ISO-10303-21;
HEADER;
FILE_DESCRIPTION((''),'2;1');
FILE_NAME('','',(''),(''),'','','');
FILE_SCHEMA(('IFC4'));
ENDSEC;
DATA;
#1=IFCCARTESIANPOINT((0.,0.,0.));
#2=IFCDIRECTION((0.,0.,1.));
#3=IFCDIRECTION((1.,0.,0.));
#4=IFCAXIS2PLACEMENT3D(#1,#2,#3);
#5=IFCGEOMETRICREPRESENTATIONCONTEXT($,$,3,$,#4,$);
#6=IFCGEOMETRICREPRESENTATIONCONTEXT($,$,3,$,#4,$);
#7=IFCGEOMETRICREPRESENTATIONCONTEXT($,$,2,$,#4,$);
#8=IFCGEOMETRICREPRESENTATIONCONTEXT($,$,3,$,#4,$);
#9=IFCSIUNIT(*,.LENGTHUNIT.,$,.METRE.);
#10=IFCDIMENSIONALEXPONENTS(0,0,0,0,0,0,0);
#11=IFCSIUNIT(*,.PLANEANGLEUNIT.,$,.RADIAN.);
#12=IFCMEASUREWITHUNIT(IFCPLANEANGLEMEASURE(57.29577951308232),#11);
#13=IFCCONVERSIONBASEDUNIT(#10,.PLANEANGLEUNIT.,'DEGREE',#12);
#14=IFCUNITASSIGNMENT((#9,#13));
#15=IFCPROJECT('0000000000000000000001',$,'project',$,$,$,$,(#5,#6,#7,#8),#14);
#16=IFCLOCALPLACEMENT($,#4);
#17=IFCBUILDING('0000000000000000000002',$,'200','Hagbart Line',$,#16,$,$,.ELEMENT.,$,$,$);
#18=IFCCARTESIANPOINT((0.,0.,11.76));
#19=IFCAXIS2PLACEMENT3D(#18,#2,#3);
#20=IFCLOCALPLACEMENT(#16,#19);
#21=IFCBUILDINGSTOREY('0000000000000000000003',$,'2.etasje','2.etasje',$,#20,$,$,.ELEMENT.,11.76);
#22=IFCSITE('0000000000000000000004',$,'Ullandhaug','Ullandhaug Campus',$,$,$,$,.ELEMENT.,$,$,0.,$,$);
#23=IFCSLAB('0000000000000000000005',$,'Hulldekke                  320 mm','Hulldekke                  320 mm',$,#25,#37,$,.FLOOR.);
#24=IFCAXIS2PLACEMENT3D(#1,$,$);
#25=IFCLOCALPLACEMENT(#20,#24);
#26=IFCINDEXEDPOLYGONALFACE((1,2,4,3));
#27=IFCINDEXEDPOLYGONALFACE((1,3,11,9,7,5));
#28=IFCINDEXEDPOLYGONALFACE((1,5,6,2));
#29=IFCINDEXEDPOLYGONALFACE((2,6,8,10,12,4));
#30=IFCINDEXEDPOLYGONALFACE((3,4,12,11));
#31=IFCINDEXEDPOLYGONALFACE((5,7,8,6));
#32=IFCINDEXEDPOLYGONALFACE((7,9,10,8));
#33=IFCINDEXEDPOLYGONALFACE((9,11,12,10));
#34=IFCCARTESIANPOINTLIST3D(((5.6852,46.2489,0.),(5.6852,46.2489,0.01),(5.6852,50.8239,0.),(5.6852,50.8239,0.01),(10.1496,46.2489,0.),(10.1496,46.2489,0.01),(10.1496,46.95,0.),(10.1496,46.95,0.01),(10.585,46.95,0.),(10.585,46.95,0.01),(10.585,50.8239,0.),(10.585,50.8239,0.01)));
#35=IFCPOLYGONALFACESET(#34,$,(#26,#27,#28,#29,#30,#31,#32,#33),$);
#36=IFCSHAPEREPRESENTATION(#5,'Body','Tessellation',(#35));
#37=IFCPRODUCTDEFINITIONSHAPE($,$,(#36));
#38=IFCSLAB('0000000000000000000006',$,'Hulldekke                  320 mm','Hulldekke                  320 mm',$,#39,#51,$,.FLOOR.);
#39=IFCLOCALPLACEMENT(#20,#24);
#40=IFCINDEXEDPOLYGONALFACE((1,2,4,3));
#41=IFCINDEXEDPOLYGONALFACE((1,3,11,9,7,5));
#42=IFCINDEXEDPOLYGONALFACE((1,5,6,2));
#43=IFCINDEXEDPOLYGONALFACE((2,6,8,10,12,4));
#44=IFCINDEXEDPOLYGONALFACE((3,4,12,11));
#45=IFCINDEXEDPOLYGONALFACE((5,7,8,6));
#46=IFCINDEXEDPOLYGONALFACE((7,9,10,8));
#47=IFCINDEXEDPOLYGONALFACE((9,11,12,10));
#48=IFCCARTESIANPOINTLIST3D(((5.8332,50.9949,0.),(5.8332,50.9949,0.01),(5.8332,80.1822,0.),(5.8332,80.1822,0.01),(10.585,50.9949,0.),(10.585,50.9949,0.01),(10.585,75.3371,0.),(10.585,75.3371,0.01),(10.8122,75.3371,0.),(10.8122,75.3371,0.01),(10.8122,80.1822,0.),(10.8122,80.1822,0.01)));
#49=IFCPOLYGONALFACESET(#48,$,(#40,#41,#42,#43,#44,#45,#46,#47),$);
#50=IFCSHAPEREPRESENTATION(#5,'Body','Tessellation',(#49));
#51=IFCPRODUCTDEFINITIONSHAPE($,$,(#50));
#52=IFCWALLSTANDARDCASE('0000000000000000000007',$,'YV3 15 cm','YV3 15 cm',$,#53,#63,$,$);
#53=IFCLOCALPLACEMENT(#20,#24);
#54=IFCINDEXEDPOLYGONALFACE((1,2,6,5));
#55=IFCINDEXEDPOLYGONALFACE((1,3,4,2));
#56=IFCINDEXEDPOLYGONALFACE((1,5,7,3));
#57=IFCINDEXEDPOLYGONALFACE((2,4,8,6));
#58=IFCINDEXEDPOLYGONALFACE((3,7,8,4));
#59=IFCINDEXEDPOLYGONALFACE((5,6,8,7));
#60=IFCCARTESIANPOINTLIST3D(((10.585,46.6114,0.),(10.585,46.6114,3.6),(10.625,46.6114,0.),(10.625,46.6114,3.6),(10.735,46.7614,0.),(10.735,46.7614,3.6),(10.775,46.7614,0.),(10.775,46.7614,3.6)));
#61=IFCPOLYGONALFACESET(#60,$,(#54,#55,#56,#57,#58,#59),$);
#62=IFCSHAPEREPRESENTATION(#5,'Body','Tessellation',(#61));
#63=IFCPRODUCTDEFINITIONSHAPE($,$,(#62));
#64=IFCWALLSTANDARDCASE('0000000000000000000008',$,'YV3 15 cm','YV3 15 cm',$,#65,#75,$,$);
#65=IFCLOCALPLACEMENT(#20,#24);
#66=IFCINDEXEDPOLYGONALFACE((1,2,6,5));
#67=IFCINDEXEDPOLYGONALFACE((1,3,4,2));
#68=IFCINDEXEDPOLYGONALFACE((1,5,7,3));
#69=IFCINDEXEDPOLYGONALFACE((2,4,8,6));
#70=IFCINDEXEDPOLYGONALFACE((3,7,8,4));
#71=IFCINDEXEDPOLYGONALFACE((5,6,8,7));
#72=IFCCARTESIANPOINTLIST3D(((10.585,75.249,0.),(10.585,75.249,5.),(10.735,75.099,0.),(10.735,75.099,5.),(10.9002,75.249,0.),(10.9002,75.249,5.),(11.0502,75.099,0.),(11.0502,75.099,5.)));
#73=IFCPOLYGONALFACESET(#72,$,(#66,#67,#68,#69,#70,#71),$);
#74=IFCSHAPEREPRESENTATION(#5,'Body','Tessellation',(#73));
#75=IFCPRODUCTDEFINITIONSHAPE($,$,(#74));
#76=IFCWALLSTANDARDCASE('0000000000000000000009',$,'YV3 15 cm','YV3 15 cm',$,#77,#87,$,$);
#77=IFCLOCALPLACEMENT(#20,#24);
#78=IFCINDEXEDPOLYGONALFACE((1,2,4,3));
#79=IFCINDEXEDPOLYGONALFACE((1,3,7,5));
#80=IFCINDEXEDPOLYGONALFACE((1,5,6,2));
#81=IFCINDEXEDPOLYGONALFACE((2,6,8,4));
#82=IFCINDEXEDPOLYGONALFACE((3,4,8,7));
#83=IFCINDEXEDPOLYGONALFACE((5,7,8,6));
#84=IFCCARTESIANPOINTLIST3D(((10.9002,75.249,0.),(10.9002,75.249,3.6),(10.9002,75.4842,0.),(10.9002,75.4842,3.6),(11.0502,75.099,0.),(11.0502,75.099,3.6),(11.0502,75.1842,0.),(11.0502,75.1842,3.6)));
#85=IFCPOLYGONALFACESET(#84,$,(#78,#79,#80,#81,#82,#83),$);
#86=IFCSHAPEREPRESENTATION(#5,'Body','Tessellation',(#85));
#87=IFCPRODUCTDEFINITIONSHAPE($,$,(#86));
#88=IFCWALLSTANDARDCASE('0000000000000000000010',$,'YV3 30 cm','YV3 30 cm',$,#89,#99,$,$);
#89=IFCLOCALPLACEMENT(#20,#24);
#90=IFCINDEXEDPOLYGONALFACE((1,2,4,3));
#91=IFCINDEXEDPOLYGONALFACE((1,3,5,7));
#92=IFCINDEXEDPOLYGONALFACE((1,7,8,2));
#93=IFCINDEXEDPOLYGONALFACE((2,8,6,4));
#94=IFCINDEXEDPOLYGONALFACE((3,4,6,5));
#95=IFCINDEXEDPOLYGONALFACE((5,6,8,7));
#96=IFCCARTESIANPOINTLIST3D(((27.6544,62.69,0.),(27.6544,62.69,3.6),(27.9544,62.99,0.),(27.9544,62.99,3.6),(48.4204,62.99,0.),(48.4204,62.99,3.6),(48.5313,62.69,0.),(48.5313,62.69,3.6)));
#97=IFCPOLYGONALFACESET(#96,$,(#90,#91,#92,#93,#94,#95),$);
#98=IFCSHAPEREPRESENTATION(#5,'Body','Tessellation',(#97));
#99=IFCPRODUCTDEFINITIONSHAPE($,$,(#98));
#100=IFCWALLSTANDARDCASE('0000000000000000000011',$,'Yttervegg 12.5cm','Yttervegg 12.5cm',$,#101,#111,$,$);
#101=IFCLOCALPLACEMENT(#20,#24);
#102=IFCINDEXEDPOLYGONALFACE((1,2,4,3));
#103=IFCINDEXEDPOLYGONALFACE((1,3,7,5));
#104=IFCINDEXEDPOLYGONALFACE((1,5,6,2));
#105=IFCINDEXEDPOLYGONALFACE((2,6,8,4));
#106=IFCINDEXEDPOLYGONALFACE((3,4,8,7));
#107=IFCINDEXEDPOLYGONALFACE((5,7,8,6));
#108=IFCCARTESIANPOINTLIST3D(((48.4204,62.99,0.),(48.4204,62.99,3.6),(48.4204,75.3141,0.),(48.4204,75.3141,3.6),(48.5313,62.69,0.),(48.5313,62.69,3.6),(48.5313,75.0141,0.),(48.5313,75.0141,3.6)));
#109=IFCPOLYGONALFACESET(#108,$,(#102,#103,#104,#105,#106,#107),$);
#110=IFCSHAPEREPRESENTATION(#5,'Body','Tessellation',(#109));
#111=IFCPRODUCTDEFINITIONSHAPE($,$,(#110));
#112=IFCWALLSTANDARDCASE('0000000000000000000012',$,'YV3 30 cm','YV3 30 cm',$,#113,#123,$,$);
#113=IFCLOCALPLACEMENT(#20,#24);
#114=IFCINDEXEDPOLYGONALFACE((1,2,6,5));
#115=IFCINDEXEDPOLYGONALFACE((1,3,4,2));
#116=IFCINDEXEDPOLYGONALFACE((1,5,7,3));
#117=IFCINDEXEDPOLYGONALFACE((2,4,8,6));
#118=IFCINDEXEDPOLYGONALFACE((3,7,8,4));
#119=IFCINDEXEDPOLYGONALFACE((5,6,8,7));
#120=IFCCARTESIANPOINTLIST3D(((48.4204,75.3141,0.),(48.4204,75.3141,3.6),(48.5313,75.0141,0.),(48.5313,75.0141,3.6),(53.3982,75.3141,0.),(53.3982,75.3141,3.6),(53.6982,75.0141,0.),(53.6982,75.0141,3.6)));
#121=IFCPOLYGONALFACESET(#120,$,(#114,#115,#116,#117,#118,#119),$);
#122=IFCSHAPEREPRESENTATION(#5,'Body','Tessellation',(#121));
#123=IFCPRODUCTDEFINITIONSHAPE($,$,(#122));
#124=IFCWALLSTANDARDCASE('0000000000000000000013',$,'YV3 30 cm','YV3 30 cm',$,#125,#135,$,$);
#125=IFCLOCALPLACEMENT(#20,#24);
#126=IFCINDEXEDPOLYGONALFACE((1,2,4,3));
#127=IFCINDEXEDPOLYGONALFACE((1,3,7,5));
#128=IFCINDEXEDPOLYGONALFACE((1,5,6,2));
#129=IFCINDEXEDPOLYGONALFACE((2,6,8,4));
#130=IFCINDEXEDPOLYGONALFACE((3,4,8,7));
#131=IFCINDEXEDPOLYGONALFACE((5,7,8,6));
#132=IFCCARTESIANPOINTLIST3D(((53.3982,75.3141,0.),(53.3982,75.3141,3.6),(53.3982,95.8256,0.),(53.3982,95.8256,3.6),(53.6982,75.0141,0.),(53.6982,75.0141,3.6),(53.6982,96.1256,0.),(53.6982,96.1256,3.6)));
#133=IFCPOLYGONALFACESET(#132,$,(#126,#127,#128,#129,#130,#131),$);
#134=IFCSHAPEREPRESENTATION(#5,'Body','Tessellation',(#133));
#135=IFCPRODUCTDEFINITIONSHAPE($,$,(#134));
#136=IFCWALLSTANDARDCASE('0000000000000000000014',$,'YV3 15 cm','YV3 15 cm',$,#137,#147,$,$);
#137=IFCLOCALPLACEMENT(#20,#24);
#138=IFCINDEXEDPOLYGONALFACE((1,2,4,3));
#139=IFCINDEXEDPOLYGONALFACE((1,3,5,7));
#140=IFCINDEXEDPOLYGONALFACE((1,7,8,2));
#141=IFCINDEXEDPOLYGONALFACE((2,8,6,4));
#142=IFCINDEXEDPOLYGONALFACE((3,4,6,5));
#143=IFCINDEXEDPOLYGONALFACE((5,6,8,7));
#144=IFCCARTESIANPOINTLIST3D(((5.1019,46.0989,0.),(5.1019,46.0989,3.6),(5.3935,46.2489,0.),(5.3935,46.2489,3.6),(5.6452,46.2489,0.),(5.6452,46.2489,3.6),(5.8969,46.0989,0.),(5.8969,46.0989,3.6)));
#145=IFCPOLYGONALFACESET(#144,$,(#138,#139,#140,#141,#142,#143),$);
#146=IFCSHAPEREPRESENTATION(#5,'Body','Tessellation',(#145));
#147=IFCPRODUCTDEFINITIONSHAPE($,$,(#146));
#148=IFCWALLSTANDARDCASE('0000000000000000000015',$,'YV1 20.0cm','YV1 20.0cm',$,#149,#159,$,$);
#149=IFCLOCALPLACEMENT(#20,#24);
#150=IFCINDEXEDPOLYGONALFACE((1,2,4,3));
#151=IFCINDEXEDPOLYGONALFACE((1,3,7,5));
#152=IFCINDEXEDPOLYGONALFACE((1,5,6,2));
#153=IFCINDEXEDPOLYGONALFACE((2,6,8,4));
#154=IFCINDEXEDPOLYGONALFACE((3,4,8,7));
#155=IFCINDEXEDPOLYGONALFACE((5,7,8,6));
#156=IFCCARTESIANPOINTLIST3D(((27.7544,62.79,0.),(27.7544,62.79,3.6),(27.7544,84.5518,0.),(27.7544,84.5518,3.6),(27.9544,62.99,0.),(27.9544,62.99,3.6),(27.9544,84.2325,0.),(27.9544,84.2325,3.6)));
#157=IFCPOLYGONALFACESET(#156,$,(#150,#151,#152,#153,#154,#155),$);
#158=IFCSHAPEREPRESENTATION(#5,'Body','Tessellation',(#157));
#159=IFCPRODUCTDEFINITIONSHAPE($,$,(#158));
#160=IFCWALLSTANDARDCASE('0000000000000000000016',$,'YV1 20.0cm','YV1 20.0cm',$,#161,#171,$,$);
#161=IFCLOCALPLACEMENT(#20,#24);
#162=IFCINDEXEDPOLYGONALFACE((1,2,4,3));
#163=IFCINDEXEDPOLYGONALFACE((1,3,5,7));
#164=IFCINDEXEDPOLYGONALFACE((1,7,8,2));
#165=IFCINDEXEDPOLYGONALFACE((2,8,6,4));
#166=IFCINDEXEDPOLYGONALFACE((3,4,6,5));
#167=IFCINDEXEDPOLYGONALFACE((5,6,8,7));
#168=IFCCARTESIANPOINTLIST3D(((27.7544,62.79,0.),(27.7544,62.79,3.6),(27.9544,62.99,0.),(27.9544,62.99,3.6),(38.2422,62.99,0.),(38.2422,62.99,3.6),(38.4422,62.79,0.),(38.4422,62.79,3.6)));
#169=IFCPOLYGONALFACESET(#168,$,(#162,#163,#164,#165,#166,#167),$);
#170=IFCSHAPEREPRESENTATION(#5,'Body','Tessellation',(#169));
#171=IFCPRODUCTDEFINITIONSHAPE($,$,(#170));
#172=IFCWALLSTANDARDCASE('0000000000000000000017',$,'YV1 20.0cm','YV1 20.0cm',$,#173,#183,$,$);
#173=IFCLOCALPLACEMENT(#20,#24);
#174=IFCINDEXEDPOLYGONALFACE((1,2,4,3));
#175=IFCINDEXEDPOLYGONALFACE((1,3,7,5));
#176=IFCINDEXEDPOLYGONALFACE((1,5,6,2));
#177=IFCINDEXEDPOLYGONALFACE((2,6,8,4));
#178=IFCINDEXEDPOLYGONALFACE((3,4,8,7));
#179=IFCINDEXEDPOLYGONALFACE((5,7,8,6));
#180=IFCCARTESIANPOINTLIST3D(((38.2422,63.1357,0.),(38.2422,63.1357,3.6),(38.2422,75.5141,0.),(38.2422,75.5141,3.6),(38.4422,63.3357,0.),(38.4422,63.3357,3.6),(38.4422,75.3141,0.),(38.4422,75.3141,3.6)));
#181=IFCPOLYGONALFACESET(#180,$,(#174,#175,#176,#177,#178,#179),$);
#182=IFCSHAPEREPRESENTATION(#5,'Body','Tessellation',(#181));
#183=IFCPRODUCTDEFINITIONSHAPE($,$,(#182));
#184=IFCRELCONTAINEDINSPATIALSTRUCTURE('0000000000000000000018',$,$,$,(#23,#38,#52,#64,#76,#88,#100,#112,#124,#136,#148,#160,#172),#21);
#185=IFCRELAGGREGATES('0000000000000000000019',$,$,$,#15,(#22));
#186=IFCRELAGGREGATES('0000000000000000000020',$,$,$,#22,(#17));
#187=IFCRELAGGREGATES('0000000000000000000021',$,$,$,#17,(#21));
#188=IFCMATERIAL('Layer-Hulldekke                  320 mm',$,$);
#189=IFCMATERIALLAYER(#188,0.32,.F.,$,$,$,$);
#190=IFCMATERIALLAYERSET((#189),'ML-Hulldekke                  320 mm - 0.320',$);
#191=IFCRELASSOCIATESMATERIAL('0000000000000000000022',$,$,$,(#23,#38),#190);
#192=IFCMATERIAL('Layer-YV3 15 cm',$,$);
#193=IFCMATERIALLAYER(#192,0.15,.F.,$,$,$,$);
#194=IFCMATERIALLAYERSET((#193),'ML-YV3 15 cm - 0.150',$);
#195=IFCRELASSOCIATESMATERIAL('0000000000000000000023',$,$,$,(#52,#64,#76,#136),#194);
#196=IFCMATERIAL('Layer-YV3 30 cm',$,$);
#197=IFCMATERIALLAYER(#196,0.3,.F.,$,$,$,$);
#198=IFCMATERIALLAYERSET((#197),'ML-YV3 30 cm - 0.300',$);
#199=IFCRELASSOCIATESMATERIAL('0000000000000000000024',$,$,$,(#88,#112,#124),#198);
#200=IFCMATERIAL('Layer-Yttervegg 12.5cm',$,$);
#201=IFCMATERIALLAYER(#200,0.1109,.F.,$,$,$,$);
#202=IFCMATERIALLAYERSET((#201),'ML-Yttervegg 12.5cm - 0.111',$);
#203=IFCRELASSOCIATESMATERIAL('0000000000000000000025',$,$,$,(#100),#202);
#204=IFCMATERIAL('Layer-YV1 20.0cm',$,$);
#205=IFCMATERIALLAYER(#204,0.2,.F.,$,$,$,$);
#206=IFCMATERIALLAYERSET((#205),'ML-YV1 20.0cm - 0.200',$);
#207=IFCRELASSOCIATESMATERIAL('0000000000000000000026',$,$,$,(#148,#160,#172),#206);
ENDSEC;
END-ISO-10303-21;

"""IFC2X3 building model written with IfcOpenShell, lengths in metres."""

from ifc_helpers import new_model, entity, si_unit, converted_unit, frame, origin_with_axes, place, context, project, spatial, polyline, outline, extrude, material, layer, layer_set, layer_usage, element, save


model = new_model("IFC2X3")

# Units and contexts
context_of_model_1 = context(None, 3, world=origin_with_axes())
context_of_model_2 = context(None, 3, world=origin_with_axes())
context_of_model_3 = context(None, 2, world=origin_with_axes())
context_of_model_4 = context(None, 3, world=origin_with_axes())
ifc_project = project(units=[si_unit("LENGTHUNIT", "METRE"), converted_unit("PLANEANGLEUNIT", "DEGREE", entity("IfcPlaneAngleMeasure", 57.29577951308232), si_unit("PLANEANGLEUNIT", "RADIAN"), dimensions=[0, 0, 0, 0, 0, 0, 0])], contexts=[context_of_model_1, context_of_model_2, context_of_model_3, context_of_model_4])

# Site, building, storey
site = spatial("IfcSite", under=ifc_project, Name="Ullandhaug", Description="Ullandhaug Campus", CompositionType="ELEMENT", RefElevation=0.0)
building_placement = place(None, origin_with_axes())
building = spatial("IfcBuilding", under=site, at=building_placement, Name="200", Description="Hagbart Line", CompositionType="ELEMENT")
storey_placement = place(building_placement, frame((0.0, 0.0, 11.76), z_axis=(0.0, 0.0, 1.0), x_axis=(1.0, 0.0, 0.0)))
storey = spatial("IfcBuildingStorey", under=building, at=storey_placement, Name="2.etasje", Description="2.etasje", CompositionType="ELEMENT", Elevation=11.76)

# Slabs
ifc_material_1 = material(Name="Layer-Hulldekke                  320 mm")
ifc_layer_1 = layer(ifc_material_1, 0.32, ventilated=False)
ifc_layer_set_1 = layer_set([ifc_layer_1], Name="ML-Hulldekke                  320 mm - 0.320")
ifc_layer_usage_1 = layer_usage(ifc_layer_set_1, "AXIS2", "POSITIVE", 0.0)
slab_1_placement = place(storey_placement, frame((5.6852, 46.2489, 0.0), z_axis=(0.0, 0.0, 1.0), x_axis=(1.0, 0.0, 0.0)))
element("IfcSlab", 1, at=slab_1_placement, inside=storey, material=ifc_layer_usage_1, Name="Hulldekke                  320 mm", Description="Hulldekke                  320 mm", PredefinedType="FLOOR", context=context_of_model_1, shape_type="SweptSolid", body=[
    extrude(outline(polyline([(0.0, 0.0), (4.4644, 0.0), (4.4644, 0.7011), (4.8998, 0.7011), (4.8998, 4.575), (0.0, 4.575), (0.0, 0.0)])), origin_with_axes(), (0.0, 0.0, 1.0), 0.01),
])
slab_2_placement = place(storey_placement, frame((5.8332, 50.9949, 0.0), z_axis=(0.0, 0.0, 1.0), x_axis=(1.0, 0.0, 0.0)))
element("IfcSlab", 2, at=slab_2_placement, inside=storey, material=ifc_layer_usage_1, Name="Hulldekke                  320 mm", Description="Hulldekke                  320 mm", PredefinedType="FLOOR", context=context_of_model_1, shape_type="SweptSolid", body=[
    extrude(outline(polyline([(0.0, 0.0), (4.7518, 0.0), (4.7518, 24.3422), (4.979, 24.3422), (4.979, 29.1873), (0.0, 29.1873), (0.0, 0.0)])), origin_with_axes(), (0.0, 0.0, 1.0), 0.01),
])

# Walls
ifc_material_2 = material(Name="Layer-YV3 15 cm")
ifc_layer_2 = layer(ifc_material_2, 0.15, ventilated=False)
ifc_layer_set_2 = layer_set([ifc_layer_2], Name="ML-YV3 15 cm - 0.150")
ifc_layer_usage_2 = layer_usage(ifc_layer_set_2, "AXIS2", "POSITIVE", 0.0)
wall_1_placement = place(storey_placement, frame((10.775, 46.7614, 0.0), z_axis=(0.0, 0.0, 1.0), x_axis=(-1.0, 0.0, 0.0)))
element("IfcWallStandardCase", 3, at=wall_1_placement, inside=storey, material=ifc_layer_usage_2, Name="YV3 15 cm", Description="YV3 15 cm", context=context_of_model_1, shape_type="SweptSolid", body=[
    extrude(outline(polyline([(0.0, 0.0), (0.04, 0.0), (0.19, 0.15), (0.15, 0.15), (0.0, 0.0)])), frame((0.0, 0.0, 0.0), z_axis=(0.0, 0.0, 1.0), x_axis=(1.0, 0.0, 0.0)), (0.0, 0.0, 1.0), 3.6),
])
wall_2_placement = place(storey_placement, frame((10.735, 75.099, 0.0), z_axis=(0.0, 0.0, 1.0), x_axis=(1.0, 0.0, 0.0)))
element("IfcWallStandardCase", 4, at=wall_2_placement, inside=storey, material=ifc_layer_usage_2, Name="YV3 15 cm", Description="YV3 15 cm", context=context_of_model_1, shape_type="SweptSolid", body=[
    extrude(outline(polyline([(0.0, 0.0), (0.3152, 0.0), (0.1652, 0.15), (-0.15, 0.15), (0.0, 0.0)])), origin_with_axes(), (0.0, 0.0, 1.0), 5.0),
])
wall_3_placement = place(storey_placement, frame((11.0502, 75.099, 0.0), z_axis=(0.0, 0.0, 1.0), x_axis=(0.0, 1.0, 0.0)))
element("IfcWallStandardCase", 5, at=wall_3_placement, inside=storey, material=ifc_layer_usage_2, Name="YV3 15 cm", Description="YV3 15 cm", context=context_of_model_1, shape_type="SweptSolid", body=[
    extrude(outline(polyline([(0.0, 0.0), (0.0852, 0.0), (0.3852, 0.15), (0.15, 0.15), (0.0, 0.0)])), frame((0.0, 0.0, 0.0), z_axis=(0.0, 0.0, 1.0), x_axis=(1.0, 0.0, 0.0)), (0.0, 0.0, 1.0), 3.6),
])
ifc_material_3 = material(Name="Layer-YV3 30 cm")
ifc_layer_3 = layer(ifc_material_3, 0.3, ventilated=False)
ifc_layer_set_3 = layer_set([ifc_layer_3], Name="ML-YV3 30 cm - 0.300")
ifc_layer_usage_3 = layer_usage(ifc_layer_set_3, "AXIS2", "POSITIVE", 0.0)
wall_4_placement = place(storey_placement, frame((27.6544, 62.69, 0.0), z_axis=(0.0, 0.0, 1.0), x_axis=(1.0, 0.0, 0.0)))
element("IfcWallStandardCase", 6, at=wall_4_placement, inside=storey, material=ifc_layer_usage_3, Name="YV3 30 cm", Description="YV3 30 cm", context=context_of_model_1, shape_type="SweptSolid", body=[
    extrude(outline(polyline([(0.0, 0.0), (20.8769, 0.0), (20.766, 0.3), (0.3, 0.3), (0.0, 0.0)])), origin_with_axes(), (0.0, 0.0, 1.0), 3.6),
])
ifc_material_4 = material(Name="Layer-Yttervegg 12.5cm")
ifc_layer_4 = layer(ifc_material_4, 0.1109, ventilated=False)
ifc_layer_set_4 = layer_set([ifc_layer_4], Name="ML-Yttervegg 12.5cm - 0.111")
ifc_layer_usage_4 = layer_usage(ifc_layer_set_4, "AXIS2", "POSITIVE", 0.0)
wall_5_placement = place(storey_placement, frame((48.5313, 62.69, 0.0), z_axis=(0.0, 0.0, 1.0), x_axis=(0.0, 1.0, 0.0)))
element("IfcWallStandardCase", 7, at=wall_5_placement, inside=storey, material=ifc_layer_usage_4, Name="Yttervegg 12.5cm", Description="Yttervegg 12.5cm", context=context_of_model_1, shape_type="SweptSolid", body=[
    extrude(outline(polyline([(0.0, 0.0), (12.3241, 0.0), (12.6241, 0.1109), (0.3, 0.1109), (0.0, 0.0)])), frame((0.0, 0.0, 0.0), z_axis=(0.0, 0.0, 1.0), x_axis=(1.0, 0.0, 0.0)), (0.0, 0.0, 1.0), 3.6),
])
wall_6_placement = place(storey_placement, frame((48.5313, 75.0141, 0.0), z_axis=(0.0, 0.0, 1.0), x_axis=(1.0, 0.0, 0.0)))
element("IfcWallStandardCase", 8, at=wall_6_placement, inside=storey, material=ifc_layer_usage_3, Name="YV3 30 cm", Description="YV3 30 cm", context=context_of_model_1, shape_type="SweptSolid", body=[
    extrude(outline(polyline([(0.0, 0.0), (5.1669, 0.0), (4.8669, 0.3), (-0.1109, 0.3), (0.0, 0.0)])), origin_with_axes(), (0.0, 0.0, 1.0), 3.6),
])
wall_7_placement = place(storey_placement, frame((53.6982, 75.0141, 0.0), z_axis=(0.0, 0.0, 1.0), x_axis=(0.0, 1.0, 0.0)))
element("IfcWallStandardCase", 9, at=wall_7_placement, inside=storey, material=ifc_layer_usage_3, Name="YV3 30 cm", Description="YV3 30 cm", context=context_of_model_1, shape_type="SweptSolid", body=[
    extrude(outline(polyline([(0.0, 0.0), (21.1115, 0.0), (20.8115, 0.3), (0.3, 0.3), (0.0, 0.0)])), frame((0.0, 0.0, 0.0), z_axis=(0.0, 0.0, 1.0), x_axis=(1.0, 0.0, 0.0)), (0.0, 0.0, 1.0), 3.6),
])
wall_8_placement = place(storey_placement, frame((5.6452, 46.2489, 0.0), z_axis=(0.0, 0.0, 1.0), x_axis=(-1.0, 0.0, 0.0)))
element("IfcWallStandardCase", 10, at=wall_8_placement, inside=storey, material=ifc_layer_usage_2, Name="YV3 15 cm", Description="YV3 15 cm", context=context_of_model_1, shape_type="SweptSolid", body=[
    extrude(outline(polyline([(0.0, 0.0), (0.2517, 0.0), (0.5433, 0.15), (-0.2517, 0.15), (0.0, 0.0)])), frame((0.0, 0.0, 0.0), z_axis=(0.0, 0.0, 1.0), x_axis=(1.0, 0.0, 0.0)), (0.0, 0.0, 1.0), 3.6),
])
ifc_material_5 = material(Name="Layer-YV1 20.0cm")
ifc_layer_5 = layer(ifc_material_5, 0.2, ventilated=False)
ifc_layer_set_5 = layer_set([ifc_layer_5], Name="ML-YV1 20.0cm - 0.200")
ifc_layer_usage_5 = layer_usage(ifc_layer_set_5, "AXIS2", "POSITIVE", 0.0)
wall_9_placement = place(storey_placement, frame((27.9544, 62.99, 0.0), z_axis=(0.0, 0.0, 1.0), x_axis=(0.0, 1.0, 0.0)))
element("IfcWallStandardCase", 11, at=wall_9_placement, inside=storey, material=ifc_layer_usage_5, Name="YV1 20.0cm", Description="YV1 20.0cm", context=context_of_model_1, shape_type="SweptSolid", body=[
    extrude(outline(polyline([(0.0, 0.0), (21.2424, 0.0), (21.5618, 0.2), (-0.2, 0.2), (0.0, 0.0)])), frame((0.0, 0.0, 0.0), z_axis=(0.0, 0.0, 1.0), x_axis=(1.0, 0.0, 0.0)), (0.0, 0.0, 1.0), 3.6),
])
wall_10_placement = place(storey_placement, frame((38.2422, 62.99, 0.0), z_axis=(0.0, 0.0, 1.0), x_axis=(-1.0, 0.0, 0.0)))
element("IfcWallStandardCase", 12, at=wall_10_placement, inside=storey, material=ifc_layer_usage_5, Name="YV1 20.0cm", Description="YV1 20.0cm", context=context_of_model_1, shape_type="SweptSolid", body=[
    extrude(outline(polyline([(0.0, 0.0), (10.2878, 0.0), (10.4878, 0.2), (-0.2, 0.2), (0.0, 0.0)])), frame((0.0, 0.0, 0.0), z_axis=(0.0, 0.0, 1.0), x_axis=(1.0, 0.0, 0.0)), (0.0, 0.0, 1.0), 3.6),
])
wall_11_placement = place(storey_placement, frame((38.4422, 63.3357, 0.0), z_axis=(0.0, 0.0, 1.0), x_axis=(0.0, 1.0, 0.0)))
element("IfcWallStandardCase", 13, at=wall_11_placement, inside=storey, material=ifc_layer_usage_5, Name="YV1 20.0cm", Description="YV1 20.0cm", context=context_of_model_1, shape_type="SweptSolid", body=[
    extrude(outline(polyline([(0.0, 0.0), (11.9784, 0.0), (12.1784, 0.2), (-0.2, 0.2), (0.0, 0.0)])), frame((0.0, 0.0, 0.0), z_axis=(0.0, 0.0, 1.0), x_axis=(1.0, 0.0, 0.0)), (0.0, 0.0, 1.0), 3.6),
])

save(model, "model.ifc")
